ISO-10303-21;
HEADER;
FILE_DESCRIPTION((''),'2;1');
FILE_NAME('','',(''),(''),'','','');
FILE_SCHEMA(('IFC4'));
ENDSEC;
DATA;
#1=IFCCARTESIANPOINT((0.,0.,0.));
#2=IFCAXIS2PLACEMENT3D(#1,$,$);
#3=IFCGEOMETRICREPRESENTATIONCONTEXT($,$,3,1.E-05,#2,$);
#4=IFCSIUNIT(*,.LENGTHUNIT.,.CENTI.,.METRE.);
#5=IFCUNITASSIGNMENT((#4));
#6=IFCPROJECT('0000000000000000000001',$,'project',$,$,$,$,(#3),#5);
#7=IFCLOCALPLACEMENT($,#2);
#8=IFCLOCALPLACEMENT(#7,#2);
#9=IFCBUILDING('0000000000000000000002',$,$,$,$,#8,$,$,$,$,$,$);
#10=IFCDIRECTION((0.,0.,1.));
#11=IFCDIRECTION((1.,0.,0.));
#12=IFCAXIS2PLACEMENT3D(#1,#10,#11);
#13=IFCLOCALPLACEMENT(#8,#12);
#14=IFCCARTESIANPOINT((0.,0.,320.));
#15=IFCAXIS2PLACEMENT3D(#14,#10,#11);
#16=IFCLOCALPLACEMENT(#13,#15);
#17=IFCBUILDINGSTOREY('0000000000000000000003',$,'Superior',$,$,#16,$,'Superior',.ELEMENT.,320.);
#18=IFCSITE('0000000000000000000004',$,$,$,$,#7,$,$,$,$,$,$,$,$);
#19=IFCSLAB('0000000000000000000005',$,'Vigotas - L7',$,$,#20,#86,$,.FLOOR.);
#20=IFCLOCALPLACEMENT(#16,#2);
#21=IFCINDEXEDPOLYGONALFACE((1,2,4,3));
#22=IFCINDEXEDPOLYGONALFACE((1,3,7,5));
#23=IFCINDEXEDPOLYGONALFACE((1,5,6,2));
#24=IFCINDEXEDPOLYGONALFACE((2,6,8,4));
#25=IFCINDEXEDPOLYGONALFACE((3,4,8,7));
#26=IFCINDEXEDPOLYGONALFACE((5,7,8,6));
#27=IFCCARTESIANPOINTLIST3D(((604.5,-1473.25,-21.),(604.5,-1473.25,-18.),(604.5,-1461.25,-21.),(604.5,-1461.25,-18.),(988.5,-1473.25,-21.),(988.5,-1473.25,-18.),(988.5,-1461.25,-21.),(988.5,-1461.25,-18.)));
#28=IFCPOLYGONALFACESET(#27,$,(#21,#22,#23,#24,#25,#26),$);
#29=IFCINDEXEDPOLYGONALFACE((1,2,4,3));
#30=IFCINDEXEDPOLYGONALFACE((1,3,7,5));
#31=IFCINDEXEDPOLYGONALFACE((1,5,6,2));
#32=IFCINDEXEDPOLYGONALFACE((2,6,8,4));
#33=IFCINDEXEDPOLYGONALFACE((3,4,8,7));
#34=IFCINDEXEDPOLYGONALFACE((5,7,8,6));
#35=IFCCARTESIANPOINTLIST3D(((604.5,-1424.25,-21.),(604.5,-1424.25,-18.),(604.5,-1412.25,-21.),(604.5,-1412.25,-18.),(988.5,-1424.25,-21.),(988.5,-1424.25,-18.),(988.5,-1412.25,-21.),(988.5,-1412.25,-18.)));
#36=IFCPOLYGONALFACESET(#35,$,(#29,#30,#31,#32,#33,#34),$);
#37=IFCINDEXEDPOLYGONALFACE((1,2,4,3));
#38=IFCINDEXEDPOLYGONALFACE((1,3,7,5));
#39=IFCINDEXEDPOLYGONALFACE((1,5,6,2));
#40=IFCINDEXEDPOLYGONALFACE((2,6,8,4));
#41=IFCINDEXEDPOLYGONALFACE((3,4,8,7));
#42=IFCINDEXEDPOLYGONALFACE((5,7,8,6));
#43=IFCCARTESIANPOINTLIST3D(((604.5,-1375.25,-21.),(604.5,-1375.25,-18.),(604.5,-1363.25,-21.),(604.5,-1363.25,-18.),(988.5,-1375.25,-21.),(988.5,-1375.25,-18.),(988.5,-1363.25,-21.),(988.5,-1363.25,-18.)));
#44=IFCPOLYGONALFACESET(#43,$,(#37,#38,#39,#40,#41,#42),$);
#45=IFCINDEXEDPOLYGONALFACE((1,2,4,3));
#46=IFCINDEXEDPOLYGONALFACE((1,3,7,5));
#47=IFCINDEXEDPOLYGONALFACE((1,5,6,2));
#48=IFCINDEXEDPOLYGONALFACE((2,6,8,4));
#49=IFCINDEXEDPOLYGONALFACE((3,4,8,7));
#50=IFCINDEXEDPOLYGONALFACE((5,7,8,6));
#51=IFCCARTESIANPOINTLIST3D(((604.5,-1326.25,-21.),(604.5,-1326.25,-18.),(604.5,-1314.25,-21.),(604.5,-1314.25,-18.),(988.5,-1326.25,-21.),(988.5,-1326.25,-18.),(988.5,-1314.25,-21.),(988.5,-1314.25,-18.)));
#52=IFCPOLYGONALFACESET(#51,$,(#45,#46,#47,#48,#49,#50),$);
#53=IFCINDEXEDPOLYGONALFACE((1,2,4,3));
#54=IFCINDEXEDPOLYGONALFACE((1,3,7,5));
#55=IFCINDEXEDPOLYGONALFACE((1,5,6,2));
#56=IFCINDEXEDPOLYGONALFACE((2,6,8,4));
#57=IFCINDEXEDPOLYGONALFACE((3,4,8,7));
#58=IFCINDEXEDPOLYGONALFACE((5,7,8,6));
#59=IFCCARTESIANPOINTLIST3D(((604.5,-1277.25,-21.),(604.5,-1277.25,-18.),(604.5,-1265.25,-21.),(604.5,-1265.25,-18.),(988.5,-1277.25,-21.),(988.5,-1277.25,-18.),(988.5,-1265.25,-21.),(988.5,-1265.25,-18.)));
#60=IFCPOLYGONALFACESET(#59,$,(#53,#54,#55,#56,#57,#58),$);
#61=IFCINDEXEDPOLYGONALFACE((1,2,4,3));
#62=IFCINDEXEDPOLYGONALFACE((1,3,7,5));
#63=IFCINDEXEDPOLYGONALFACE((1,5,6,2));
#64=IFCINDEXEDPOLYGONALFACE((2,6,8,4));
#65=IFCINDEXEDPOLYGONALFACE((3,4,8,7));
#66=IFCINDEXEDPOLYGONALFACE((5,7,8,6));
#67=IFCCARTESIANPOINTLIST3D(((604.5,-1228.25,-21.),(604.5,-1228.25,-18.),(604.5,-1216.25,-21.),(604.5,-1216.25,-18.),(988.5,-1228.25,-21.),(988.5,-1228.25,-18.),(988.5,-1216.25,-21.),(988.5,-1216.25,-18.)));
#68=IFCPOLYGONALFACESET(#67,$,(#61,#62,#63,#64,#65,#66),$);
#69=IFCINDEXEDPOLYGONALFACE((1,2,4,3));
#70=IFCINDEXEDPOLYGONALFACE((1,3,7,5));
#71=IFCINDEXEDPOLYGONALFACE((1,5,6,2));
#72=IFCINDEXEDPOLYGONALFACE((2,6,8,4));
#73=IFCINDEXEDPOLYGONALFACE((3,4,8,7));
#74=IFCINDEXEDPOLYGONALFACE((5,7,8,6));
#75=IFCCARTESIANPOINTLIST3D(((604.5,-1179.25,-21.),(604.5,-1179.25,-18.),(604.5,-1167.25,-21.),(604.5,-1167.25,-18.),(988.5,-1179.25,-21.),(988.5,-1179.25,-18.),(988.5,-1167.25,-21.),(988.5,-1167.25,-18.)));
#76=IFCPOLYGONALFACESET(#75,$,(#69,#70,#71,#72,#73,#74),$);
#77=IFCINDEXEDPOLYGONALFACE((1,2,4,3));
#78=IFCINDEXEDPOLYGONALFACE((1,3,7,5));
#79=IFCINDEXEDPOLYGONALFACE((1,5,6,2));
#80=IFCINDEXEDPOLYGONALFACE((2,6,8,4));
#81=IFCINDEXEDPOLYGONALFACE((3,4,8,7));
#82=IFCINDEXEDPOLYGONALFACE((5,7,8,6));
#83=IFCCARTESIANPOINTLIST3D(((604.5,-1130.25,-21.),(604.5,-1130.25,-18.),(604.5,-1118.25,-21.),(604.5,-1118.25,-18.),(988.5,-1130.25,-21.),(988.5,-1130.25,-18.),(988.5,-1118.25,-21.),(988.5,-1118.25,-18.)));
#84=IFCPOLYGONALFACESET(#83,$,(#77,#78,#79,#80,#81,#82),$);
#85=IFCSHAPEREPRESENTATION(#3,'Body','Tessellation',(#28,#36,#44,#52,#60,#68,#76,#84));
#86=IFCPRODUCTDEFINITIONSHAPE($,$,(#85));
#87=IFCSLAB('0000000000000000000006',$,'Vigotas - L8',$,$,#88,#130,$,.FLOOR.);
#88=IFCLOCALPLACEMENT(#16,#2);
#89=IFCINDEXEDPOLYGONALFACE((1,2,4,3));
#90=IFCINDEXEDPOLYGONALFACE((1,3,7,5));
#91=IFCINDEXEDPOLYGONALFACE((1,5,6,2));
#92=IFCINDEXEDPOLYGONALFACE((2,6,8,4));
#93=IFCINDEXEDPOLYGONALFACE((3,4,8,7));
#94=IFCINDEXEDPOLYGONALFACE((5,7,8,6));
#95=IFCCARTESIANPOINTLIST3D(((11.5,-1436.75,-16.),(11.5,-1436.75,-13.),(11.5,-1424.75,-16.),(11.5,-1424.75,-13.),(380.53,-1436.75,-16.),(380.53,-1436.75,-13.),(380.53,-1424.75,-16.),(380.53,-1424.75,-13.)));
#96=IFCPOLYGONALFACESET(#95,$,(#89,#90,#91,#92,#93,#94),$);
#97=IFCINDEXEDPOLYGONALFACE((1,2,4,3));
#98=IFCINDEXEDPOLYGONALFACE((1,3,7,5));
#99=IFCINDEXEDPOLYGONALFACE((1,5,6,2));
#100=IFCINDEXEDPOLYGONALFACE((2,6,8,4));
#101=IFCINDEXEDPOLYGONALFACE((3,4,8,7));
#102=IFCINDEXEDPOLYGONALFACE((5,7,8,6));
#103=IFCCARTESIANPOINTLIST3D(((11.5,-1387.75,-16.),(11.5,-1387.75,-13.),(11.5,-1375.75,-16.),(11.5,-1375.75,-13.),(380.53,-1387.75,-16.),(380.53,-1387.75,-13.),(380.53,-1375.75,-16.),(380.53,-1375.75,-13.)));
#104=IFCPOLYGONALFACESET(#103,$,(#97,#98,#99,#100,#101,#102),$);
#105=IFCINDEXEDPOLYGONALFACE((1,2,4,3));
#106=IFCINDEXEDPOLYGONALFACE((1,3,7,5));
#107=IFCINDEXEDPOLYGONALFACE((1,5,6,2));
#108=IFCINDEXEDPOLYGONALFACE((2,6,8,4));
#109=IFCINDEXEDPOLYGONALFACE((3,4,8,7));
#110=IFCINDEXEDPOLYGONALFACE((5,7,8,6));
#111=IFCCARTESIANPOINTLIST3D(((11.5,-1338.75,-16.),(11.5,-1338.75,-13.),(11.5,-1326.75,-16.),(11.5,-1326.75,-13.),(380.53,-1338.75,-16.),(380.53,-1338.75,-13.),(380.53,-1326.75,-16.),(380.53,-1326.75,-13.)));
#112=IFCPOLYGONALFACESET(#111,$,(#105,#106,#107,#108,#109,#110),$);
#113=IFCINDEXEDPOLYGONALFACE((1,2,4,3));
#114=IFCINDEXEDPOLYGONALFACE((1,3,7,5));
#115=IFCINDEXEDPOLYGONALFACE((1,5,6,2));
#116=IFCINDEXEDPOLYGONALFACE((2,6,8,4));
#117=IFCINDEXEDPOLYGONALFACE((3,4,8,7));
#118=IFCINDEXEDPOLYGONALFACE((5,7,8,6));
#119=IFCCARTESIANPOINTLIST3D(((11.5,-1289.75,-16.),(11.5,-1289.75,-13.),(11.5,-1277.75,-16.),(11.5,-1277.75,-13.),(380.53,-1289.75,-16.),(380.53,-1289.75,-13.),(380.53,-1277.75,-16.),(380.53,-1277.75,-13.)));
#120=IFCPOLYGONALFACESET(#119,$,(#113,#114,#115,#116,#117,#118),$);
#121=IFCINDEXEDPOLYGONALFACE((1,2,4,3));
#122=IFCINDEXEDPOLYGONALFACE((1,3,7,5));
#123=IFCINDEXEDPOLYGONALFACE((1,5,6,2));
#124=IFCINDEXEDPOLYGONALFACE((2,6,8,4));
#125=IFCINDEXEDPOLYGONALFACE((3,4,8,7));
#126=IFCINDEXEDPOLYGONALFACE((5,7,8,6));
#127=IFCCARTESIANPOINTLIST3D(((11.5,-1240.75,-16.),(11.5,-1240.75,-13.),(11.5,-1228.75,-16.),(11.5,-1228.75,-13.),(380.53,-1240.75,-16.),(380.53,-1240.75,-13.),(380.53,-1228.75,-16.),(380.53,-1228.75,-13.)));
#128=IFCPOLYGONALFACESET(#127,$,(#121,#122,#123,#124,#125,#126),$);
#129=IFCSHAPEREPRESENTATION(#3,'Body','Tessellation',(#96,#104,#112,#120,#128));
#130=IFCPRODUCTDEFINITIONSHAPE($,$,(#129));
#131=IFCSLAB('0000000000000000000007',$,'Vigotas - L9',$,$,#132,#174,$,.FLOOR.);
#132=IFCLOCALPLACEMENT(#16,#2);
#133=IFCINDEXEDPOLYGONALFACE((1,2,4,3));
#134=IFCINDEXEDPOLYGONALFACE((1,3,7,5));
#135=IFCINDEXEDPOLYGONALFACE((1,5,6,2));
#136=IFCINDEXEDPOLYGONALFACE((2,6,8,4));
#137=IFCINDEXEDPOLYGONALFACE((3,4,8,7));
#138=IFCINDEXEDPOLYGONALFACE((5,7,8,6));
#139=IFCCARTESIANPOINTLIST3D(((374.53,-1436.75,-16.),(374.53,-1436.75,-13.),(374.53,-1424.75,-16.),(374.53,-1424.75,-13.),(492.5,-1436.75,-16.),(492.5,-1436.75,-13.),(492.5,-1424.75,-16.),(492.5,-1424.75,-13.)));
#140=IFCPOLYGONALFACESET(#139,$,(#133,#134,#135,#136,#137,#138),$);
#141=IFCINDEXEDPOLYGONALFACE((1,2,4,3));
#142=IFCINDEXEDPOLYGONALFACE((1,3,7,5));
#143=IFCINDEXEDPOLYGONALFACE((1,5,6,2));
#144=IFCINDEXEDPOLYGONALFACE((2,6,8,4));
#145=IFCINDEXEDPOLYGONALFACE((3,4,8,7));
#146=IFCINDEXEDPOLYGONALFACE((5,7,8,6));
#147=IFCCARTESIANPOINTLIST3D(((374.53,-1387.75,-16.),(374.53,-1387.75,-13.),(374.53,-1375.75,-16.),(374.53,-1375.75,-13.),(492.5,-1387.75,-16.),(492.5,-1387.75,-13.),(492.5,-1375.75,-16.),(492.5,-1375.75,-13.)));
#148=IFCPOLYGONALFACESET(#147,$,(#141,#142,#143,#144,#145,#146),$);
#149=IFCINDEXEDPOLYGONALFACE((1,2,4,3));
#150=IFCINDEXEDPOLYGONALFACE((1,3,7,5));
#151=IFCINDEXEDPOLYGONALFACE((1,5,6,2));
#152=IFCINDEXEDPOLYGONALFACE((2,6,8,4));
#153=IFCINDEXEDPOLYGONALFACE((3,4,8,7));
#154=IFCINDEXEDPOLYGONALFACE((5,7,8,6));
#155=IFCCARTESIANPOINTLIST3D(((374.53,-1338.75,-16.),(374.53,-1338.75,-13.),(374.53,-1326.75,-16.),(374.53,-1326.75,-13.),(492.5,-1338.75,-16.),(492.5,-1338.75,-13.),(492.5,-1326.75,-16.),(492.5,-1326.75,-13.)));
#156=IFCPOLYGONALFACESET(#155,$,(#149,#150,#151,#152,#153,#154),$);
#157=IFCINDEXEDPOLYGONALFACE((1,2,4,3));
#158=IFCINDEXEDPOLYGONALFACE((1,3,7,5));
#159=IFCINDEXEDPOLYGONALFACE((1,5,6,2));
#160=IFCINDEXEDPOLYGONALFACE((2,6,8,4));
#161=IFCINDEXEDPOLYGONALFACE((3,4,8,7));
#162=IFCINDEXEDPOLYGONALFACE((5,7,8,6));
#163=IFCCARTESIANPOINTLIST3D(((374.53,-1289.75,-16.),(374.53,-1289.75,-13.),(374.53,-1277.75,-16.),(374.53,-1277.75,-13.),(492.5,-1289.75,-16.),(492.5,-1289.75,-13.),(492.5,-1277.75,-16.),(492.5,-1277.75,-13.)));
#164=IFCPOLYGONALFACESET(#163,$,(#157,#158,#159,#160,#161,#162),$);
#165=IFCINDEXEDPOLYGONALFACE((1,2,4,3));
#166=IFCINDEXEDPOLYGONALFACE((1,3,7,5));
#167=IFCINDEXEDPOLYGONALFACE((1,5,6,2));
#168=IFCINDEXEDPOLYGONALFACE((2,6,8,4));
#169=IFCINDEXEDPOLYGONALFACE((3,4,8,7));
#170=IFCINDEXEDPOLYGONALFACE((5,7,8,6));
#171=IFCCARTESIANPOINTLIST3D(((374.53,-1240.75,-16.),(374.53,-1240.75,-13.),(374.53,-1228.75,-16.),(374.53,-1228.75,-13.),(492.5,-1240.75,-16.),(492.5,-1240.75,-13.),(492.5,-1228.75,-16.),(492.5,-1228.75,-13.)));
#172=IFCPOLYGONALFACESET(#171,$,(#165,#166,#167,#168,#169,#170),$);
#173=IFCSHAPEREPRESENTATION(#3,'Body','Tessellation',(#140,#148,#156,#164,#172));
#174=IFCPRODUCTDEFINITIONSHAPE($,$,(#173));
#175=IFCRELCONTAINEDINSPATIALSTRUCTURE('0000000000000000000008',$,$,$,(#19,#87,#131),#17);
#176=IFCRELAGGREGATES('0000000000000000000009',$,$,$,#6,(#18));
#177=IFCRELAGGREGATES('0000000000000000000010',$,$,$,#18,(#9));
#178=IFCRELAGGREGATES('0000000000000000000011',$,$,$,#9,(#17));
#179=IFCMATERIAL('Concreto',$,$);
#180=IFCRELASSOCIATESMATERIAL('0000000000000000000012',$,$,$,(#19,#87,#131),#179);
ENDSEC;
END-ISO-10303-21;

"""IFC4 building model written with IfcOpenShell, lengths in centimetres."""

from ifc_helpers import new_model, si_unit, frame, origin, origin_with_axes, place, context, project, spatial, polyline, outline, extrude, material, element, save


model = new_model("IFC4")

# Units and contexts
context_of_model = context(None, 3, precision=1e-05, world=origin())
ifc_project = project(units=[si_unit("LENGTHUNIT", "METRE", prefix="CENTI")], contexts=[context_of_model])

# Site, building, storey
site_placement = place(None, origin())
site = spatial("IfcSite", under=ifc_project, at=site_placement)
building_placement = place(site_placement, origin())
building = spatial("IfcBuilding", under=site, at=building_placement)
placement = place(building_placement, origin_with_axes())
storey_placement = place(placement, frame((0.0, 0.0, 320.0), z_axis=(0.0, 0.0, 1.0), x_axis=(1.0, 0.0, 0.0)))
storey = spatial("IfcBuildingStorey", under=building, at=storey_placement, Name="Superior", LongName="Superior", CompositionType="ELEMENT", Elevation=320.0)

# Shared definitions
ifc_material = material(Name="Concreto")

# Slabs
slab_1_placement = place(storey_placement, frame((796.5, -1295.75, -18.0), z_axis=(0.0, 0.0, 1.0), x_axis=(1.0, 0.0, 0.0)))
element("IfcSlab", 1, at=slab_1_placement, inside=storey, material=ifc_material, Name="Vigotas - L7", PredefinedType="FLOOR", context=context_of_model, shape_type="SolidModel", body=[
    extrude(outline(polyline([(6.0, 1.5), (-6.0, 1.5), (-6.0, -1.5), (6.0, -1.5), (6.0, 1.5), (6.0, 1.5)])), frame((-192.0, -171.5, -1.5), z_axis=(1.0, 0.0, 0.0), x_axis=(0.0, -1.0, 0.0)), (0.0, 0.0, 1.0), 384.0),
    extrude(outline(polyline([(6.0, 1.5), (-6.0, 1.5), (-6.0, -1.5), (6.0, -1.5), (6.0, 1.5), (6.0, 1.5)])), frame((-192.0, -122.5, -1.5), z_axis=(1.0, 0.0, 0.0), x_axis=(0.0, -1.0, 0.0)), (0.0, 0.0, 1.0), 384.0),
    extrude(outline(polyline([(6.0, 1.5), (-6.0, 1.5), (-6.0, -1.5), (6.0, -1.5), (6.0, 1.5), (6.0, 1.5)])), frame((-192.0, -73.5, -1.5), z_axis=(1.0, 0.0, 0.0), x_axis=(0.0, -1.0, 0.0)), (0.0, 0.0, 1.0), 384.0),
    extrude(outline(polyline([(6.0, 1.5), (-6.0, 1.5), (-6.0, -1.5), (6.0, -1.5), (6.0, 1.5), (6.0, 1.5)])), frame((-192.0, -24.5, -1.5), z_axis=(1.0, 0.0, 0.0), x_axis=(0.0, -1.0, 0.0)), (0.0, 0.0, 1.0), 384.0),
    extrude(outline(polyline([(6.0, 1.5), (-6.0, 1.5), (-6.0, -1.5), (6.0, -1.5), (6.0, 1.5), (6.0, 1.5)])), frame((-192.0, 24.5, -1.5), z_axis=(1.0, 0.0, 0.0), x_axis=(0.0, -1.0, 0.0)), (0.0, 0.0, 1.0), 384.0),
    extrude(outline(polyline([(6.0, 1.5), (-6.0, 1.5), (-6.0, -1.5), (6.0, -1.5), (6.0, 1.5), (6.0, 1.5)])), frame((-192.0, 73.5, -1.5), z_axis=(1.0, 0.0, 0.0), x_axis=(0.0, -1.0, 0.0)), (0.0, 0.0, 1.0), 384.0),
    extrude(outline(polyline([(6.0, 1.5), (-6.0, 1.5), (-6.0, -1.5), (6.0, -1.5), (6.0, 1.5), (6.0, 1.5)])), frame((-192.0, 122.5, -1.5), z_axis=(1.0, 0.0, 0.0), x_axis=(0.0, -1.0, 0.0)), (0.0, 0.0, 1.0), 384.0),
    extrude(outline(polyline([(6.0, 1.5), (-6.0, 1.5), (-6.0, -1.5), (6.0, -1.5), (6.0, 1.5), (6.0, 1.5)])), frame((-192.0, 171.5, -1.5), z_axis=(1.0, 0.0, 0.0), x_axis=(0.0, -1.0, 0.0)), (0.0, 0.0, 1.0), 384.0),
])
slab_2_placement = place(storey_placement, frame((196.01, -1332.75, -13.0), z_axis=(0.0, 0.0, 1.0), x_axis=(1.0, 0.0, 0.0)))
element("IfcSlab", 2, at=slab_2_placement, inside=storey, material=ifc_material, Name="Vigotas - L8", PredefinedType="FLOOR", context=context_of_model, shape_type="SolidModel", body=[
    extrude(outline(polyline([(6.0, 1.5), (-6.0, 1.5), (-6.0, -1.5), (6.0, -1.5), (6.0, 1.5), (6.0, 1.5)])), frame((-184.51, -98.0, -1.5), z_axis=(1.0, 0.0, 0.0), x_axis=(0.0, -1.0, 0.0)), (0.0, 0.0, 1.0), 369.03),
    extrude(outline(polyline([(6.0, 1.5), (-6.0, 1.5), (-6.0, -1.5), (6.0, -1.5), (6.0, 1.5), (6.0, 1.5)])), frame((-184.51, -49.0, -1.5), z_axis=(1.0, 0.0, 0.0), x_axis=(0.0, -1.0, 0.0)), (0.0, 0.0, 1.0), 369.03),
    extrude(outline(polyline([(6.0, 1.5), (-6.0, 1.5), (-6.0, -1.5), (6.0, -1.5), (6.0, 1.5), (6.0, 1.5)])), frame((-184.51, 0.0, -1.5), z_axis=(1.0, 0.0, 0.0), x_axis=(0.0, -1.0, 0.0)), (0.0, 0.0, 1.0), 369.03),
    extrude(outline(polyline([(6.0, 1.5), (-6.0, 1.5), (-6.0, -1.5), (6.0, -1.5), (6.0, 1.5), (6.0, 1.5)])), frame((-184.51, 49.0, -1.5), z_axis=(1.0, 0.0, 0.0), x_axis=(0.0, -1.0, 0.0)), (0.0, 0.0, 1.0), 369.03),
    extrude(outline(polyline([(6.0, 1.5), (-6.0, 1.5), (-6.0, -1.5), (6.0, -1.5), (6.0, 1.5), (6.0, 1.5)])), frame((-184.51, 98.0, -1.5), z_axis=(1.0, 0.0, 0.0), x_axis=(0.0, -1.0, 0.0)), (0.0, 0.0, 1.0), 369.03),
])
slab_3_placement = place(storey_placement, frame((433.51, -1332.75, -13.0), z_axis=(0.0, 0.0, 1.0), x_axis=(1.0, 0.0, 0.0)))
element("IfcSlab", 3, at=slab_3_placement, inside=storey, material=ifc_material, Name="Vigotas - L9", PredefinedType="FLOOR", context=context_of_model, shape_type="SolidModel", body=[
    extrude(outline(polyline([(6.0, 1.5), (-6.0, 1.5), (-6.0, -1.5), (6.0, -1.5), (6.0, 1.5), (6.0, 1.5)])), frame((-58.98, -98.0, -1.5), z_axis=(1.0, 0.0, 0.0), x_axis=(0.0, -1.0, 0.0)), (0.0, 0.0, 1.0), 117.97),
    extrude(outline(polyline([(6.0, 1.5), (-6.0, 1.5), (-6.0, -1.5), (6.0, -1.5), (6.0, 1.5), (6.0, 1.5)])), frame((-58.98, -49.0, -1.5), z_axis=(1.0, 0.0, 0.0), x_axis=(0.0, -1.0, 0.0)), (0.0, 0.0, 1.0), 117.97),
    extrude(outline(polyline([(6.0, 1.5), (-6.0, 1.5), (-6.0, -1.5), (6.0, -1.5), (6.0, 1.5), (6.0, 1.5)])), frame((-58.98, 0.0, -1.5), z_axis=(1.0, 0.0, 0.0), x_axis=(0.0, -1.0, 0.0)), (0.0, 0.0, 1.0), 117.97),
    extrude(outline(polyline([(6.0, 1.5), (-6.0, 1.5), (-6.0, -1.5), (6.0, -1.5), (6.0, 1.5), (6.0, 1.5)])), frame((-58.98, 49.0, -1.5), z_axis=(1.0, 0.0, 0.0), x_axis=(0.0, -1.0, 0.0)), (0.0, 0.0, 1.0), 117.97),
    extrude(outline(polyline([(6.0, 1.5), (-6.0, 1.5), (-6.0, -1.5), (6.0, -1.5), (6.0, 1.5), (6.0, 1.5)])), frame((-58.98, 98.0, -1.5), z_axis=(1.0, 0.0, 0.0), x_axis=(0.0, -1.0, 0.0)), (0.0, 0.0, 1.0), 117.97),
])

save(model, "model.ifc")
